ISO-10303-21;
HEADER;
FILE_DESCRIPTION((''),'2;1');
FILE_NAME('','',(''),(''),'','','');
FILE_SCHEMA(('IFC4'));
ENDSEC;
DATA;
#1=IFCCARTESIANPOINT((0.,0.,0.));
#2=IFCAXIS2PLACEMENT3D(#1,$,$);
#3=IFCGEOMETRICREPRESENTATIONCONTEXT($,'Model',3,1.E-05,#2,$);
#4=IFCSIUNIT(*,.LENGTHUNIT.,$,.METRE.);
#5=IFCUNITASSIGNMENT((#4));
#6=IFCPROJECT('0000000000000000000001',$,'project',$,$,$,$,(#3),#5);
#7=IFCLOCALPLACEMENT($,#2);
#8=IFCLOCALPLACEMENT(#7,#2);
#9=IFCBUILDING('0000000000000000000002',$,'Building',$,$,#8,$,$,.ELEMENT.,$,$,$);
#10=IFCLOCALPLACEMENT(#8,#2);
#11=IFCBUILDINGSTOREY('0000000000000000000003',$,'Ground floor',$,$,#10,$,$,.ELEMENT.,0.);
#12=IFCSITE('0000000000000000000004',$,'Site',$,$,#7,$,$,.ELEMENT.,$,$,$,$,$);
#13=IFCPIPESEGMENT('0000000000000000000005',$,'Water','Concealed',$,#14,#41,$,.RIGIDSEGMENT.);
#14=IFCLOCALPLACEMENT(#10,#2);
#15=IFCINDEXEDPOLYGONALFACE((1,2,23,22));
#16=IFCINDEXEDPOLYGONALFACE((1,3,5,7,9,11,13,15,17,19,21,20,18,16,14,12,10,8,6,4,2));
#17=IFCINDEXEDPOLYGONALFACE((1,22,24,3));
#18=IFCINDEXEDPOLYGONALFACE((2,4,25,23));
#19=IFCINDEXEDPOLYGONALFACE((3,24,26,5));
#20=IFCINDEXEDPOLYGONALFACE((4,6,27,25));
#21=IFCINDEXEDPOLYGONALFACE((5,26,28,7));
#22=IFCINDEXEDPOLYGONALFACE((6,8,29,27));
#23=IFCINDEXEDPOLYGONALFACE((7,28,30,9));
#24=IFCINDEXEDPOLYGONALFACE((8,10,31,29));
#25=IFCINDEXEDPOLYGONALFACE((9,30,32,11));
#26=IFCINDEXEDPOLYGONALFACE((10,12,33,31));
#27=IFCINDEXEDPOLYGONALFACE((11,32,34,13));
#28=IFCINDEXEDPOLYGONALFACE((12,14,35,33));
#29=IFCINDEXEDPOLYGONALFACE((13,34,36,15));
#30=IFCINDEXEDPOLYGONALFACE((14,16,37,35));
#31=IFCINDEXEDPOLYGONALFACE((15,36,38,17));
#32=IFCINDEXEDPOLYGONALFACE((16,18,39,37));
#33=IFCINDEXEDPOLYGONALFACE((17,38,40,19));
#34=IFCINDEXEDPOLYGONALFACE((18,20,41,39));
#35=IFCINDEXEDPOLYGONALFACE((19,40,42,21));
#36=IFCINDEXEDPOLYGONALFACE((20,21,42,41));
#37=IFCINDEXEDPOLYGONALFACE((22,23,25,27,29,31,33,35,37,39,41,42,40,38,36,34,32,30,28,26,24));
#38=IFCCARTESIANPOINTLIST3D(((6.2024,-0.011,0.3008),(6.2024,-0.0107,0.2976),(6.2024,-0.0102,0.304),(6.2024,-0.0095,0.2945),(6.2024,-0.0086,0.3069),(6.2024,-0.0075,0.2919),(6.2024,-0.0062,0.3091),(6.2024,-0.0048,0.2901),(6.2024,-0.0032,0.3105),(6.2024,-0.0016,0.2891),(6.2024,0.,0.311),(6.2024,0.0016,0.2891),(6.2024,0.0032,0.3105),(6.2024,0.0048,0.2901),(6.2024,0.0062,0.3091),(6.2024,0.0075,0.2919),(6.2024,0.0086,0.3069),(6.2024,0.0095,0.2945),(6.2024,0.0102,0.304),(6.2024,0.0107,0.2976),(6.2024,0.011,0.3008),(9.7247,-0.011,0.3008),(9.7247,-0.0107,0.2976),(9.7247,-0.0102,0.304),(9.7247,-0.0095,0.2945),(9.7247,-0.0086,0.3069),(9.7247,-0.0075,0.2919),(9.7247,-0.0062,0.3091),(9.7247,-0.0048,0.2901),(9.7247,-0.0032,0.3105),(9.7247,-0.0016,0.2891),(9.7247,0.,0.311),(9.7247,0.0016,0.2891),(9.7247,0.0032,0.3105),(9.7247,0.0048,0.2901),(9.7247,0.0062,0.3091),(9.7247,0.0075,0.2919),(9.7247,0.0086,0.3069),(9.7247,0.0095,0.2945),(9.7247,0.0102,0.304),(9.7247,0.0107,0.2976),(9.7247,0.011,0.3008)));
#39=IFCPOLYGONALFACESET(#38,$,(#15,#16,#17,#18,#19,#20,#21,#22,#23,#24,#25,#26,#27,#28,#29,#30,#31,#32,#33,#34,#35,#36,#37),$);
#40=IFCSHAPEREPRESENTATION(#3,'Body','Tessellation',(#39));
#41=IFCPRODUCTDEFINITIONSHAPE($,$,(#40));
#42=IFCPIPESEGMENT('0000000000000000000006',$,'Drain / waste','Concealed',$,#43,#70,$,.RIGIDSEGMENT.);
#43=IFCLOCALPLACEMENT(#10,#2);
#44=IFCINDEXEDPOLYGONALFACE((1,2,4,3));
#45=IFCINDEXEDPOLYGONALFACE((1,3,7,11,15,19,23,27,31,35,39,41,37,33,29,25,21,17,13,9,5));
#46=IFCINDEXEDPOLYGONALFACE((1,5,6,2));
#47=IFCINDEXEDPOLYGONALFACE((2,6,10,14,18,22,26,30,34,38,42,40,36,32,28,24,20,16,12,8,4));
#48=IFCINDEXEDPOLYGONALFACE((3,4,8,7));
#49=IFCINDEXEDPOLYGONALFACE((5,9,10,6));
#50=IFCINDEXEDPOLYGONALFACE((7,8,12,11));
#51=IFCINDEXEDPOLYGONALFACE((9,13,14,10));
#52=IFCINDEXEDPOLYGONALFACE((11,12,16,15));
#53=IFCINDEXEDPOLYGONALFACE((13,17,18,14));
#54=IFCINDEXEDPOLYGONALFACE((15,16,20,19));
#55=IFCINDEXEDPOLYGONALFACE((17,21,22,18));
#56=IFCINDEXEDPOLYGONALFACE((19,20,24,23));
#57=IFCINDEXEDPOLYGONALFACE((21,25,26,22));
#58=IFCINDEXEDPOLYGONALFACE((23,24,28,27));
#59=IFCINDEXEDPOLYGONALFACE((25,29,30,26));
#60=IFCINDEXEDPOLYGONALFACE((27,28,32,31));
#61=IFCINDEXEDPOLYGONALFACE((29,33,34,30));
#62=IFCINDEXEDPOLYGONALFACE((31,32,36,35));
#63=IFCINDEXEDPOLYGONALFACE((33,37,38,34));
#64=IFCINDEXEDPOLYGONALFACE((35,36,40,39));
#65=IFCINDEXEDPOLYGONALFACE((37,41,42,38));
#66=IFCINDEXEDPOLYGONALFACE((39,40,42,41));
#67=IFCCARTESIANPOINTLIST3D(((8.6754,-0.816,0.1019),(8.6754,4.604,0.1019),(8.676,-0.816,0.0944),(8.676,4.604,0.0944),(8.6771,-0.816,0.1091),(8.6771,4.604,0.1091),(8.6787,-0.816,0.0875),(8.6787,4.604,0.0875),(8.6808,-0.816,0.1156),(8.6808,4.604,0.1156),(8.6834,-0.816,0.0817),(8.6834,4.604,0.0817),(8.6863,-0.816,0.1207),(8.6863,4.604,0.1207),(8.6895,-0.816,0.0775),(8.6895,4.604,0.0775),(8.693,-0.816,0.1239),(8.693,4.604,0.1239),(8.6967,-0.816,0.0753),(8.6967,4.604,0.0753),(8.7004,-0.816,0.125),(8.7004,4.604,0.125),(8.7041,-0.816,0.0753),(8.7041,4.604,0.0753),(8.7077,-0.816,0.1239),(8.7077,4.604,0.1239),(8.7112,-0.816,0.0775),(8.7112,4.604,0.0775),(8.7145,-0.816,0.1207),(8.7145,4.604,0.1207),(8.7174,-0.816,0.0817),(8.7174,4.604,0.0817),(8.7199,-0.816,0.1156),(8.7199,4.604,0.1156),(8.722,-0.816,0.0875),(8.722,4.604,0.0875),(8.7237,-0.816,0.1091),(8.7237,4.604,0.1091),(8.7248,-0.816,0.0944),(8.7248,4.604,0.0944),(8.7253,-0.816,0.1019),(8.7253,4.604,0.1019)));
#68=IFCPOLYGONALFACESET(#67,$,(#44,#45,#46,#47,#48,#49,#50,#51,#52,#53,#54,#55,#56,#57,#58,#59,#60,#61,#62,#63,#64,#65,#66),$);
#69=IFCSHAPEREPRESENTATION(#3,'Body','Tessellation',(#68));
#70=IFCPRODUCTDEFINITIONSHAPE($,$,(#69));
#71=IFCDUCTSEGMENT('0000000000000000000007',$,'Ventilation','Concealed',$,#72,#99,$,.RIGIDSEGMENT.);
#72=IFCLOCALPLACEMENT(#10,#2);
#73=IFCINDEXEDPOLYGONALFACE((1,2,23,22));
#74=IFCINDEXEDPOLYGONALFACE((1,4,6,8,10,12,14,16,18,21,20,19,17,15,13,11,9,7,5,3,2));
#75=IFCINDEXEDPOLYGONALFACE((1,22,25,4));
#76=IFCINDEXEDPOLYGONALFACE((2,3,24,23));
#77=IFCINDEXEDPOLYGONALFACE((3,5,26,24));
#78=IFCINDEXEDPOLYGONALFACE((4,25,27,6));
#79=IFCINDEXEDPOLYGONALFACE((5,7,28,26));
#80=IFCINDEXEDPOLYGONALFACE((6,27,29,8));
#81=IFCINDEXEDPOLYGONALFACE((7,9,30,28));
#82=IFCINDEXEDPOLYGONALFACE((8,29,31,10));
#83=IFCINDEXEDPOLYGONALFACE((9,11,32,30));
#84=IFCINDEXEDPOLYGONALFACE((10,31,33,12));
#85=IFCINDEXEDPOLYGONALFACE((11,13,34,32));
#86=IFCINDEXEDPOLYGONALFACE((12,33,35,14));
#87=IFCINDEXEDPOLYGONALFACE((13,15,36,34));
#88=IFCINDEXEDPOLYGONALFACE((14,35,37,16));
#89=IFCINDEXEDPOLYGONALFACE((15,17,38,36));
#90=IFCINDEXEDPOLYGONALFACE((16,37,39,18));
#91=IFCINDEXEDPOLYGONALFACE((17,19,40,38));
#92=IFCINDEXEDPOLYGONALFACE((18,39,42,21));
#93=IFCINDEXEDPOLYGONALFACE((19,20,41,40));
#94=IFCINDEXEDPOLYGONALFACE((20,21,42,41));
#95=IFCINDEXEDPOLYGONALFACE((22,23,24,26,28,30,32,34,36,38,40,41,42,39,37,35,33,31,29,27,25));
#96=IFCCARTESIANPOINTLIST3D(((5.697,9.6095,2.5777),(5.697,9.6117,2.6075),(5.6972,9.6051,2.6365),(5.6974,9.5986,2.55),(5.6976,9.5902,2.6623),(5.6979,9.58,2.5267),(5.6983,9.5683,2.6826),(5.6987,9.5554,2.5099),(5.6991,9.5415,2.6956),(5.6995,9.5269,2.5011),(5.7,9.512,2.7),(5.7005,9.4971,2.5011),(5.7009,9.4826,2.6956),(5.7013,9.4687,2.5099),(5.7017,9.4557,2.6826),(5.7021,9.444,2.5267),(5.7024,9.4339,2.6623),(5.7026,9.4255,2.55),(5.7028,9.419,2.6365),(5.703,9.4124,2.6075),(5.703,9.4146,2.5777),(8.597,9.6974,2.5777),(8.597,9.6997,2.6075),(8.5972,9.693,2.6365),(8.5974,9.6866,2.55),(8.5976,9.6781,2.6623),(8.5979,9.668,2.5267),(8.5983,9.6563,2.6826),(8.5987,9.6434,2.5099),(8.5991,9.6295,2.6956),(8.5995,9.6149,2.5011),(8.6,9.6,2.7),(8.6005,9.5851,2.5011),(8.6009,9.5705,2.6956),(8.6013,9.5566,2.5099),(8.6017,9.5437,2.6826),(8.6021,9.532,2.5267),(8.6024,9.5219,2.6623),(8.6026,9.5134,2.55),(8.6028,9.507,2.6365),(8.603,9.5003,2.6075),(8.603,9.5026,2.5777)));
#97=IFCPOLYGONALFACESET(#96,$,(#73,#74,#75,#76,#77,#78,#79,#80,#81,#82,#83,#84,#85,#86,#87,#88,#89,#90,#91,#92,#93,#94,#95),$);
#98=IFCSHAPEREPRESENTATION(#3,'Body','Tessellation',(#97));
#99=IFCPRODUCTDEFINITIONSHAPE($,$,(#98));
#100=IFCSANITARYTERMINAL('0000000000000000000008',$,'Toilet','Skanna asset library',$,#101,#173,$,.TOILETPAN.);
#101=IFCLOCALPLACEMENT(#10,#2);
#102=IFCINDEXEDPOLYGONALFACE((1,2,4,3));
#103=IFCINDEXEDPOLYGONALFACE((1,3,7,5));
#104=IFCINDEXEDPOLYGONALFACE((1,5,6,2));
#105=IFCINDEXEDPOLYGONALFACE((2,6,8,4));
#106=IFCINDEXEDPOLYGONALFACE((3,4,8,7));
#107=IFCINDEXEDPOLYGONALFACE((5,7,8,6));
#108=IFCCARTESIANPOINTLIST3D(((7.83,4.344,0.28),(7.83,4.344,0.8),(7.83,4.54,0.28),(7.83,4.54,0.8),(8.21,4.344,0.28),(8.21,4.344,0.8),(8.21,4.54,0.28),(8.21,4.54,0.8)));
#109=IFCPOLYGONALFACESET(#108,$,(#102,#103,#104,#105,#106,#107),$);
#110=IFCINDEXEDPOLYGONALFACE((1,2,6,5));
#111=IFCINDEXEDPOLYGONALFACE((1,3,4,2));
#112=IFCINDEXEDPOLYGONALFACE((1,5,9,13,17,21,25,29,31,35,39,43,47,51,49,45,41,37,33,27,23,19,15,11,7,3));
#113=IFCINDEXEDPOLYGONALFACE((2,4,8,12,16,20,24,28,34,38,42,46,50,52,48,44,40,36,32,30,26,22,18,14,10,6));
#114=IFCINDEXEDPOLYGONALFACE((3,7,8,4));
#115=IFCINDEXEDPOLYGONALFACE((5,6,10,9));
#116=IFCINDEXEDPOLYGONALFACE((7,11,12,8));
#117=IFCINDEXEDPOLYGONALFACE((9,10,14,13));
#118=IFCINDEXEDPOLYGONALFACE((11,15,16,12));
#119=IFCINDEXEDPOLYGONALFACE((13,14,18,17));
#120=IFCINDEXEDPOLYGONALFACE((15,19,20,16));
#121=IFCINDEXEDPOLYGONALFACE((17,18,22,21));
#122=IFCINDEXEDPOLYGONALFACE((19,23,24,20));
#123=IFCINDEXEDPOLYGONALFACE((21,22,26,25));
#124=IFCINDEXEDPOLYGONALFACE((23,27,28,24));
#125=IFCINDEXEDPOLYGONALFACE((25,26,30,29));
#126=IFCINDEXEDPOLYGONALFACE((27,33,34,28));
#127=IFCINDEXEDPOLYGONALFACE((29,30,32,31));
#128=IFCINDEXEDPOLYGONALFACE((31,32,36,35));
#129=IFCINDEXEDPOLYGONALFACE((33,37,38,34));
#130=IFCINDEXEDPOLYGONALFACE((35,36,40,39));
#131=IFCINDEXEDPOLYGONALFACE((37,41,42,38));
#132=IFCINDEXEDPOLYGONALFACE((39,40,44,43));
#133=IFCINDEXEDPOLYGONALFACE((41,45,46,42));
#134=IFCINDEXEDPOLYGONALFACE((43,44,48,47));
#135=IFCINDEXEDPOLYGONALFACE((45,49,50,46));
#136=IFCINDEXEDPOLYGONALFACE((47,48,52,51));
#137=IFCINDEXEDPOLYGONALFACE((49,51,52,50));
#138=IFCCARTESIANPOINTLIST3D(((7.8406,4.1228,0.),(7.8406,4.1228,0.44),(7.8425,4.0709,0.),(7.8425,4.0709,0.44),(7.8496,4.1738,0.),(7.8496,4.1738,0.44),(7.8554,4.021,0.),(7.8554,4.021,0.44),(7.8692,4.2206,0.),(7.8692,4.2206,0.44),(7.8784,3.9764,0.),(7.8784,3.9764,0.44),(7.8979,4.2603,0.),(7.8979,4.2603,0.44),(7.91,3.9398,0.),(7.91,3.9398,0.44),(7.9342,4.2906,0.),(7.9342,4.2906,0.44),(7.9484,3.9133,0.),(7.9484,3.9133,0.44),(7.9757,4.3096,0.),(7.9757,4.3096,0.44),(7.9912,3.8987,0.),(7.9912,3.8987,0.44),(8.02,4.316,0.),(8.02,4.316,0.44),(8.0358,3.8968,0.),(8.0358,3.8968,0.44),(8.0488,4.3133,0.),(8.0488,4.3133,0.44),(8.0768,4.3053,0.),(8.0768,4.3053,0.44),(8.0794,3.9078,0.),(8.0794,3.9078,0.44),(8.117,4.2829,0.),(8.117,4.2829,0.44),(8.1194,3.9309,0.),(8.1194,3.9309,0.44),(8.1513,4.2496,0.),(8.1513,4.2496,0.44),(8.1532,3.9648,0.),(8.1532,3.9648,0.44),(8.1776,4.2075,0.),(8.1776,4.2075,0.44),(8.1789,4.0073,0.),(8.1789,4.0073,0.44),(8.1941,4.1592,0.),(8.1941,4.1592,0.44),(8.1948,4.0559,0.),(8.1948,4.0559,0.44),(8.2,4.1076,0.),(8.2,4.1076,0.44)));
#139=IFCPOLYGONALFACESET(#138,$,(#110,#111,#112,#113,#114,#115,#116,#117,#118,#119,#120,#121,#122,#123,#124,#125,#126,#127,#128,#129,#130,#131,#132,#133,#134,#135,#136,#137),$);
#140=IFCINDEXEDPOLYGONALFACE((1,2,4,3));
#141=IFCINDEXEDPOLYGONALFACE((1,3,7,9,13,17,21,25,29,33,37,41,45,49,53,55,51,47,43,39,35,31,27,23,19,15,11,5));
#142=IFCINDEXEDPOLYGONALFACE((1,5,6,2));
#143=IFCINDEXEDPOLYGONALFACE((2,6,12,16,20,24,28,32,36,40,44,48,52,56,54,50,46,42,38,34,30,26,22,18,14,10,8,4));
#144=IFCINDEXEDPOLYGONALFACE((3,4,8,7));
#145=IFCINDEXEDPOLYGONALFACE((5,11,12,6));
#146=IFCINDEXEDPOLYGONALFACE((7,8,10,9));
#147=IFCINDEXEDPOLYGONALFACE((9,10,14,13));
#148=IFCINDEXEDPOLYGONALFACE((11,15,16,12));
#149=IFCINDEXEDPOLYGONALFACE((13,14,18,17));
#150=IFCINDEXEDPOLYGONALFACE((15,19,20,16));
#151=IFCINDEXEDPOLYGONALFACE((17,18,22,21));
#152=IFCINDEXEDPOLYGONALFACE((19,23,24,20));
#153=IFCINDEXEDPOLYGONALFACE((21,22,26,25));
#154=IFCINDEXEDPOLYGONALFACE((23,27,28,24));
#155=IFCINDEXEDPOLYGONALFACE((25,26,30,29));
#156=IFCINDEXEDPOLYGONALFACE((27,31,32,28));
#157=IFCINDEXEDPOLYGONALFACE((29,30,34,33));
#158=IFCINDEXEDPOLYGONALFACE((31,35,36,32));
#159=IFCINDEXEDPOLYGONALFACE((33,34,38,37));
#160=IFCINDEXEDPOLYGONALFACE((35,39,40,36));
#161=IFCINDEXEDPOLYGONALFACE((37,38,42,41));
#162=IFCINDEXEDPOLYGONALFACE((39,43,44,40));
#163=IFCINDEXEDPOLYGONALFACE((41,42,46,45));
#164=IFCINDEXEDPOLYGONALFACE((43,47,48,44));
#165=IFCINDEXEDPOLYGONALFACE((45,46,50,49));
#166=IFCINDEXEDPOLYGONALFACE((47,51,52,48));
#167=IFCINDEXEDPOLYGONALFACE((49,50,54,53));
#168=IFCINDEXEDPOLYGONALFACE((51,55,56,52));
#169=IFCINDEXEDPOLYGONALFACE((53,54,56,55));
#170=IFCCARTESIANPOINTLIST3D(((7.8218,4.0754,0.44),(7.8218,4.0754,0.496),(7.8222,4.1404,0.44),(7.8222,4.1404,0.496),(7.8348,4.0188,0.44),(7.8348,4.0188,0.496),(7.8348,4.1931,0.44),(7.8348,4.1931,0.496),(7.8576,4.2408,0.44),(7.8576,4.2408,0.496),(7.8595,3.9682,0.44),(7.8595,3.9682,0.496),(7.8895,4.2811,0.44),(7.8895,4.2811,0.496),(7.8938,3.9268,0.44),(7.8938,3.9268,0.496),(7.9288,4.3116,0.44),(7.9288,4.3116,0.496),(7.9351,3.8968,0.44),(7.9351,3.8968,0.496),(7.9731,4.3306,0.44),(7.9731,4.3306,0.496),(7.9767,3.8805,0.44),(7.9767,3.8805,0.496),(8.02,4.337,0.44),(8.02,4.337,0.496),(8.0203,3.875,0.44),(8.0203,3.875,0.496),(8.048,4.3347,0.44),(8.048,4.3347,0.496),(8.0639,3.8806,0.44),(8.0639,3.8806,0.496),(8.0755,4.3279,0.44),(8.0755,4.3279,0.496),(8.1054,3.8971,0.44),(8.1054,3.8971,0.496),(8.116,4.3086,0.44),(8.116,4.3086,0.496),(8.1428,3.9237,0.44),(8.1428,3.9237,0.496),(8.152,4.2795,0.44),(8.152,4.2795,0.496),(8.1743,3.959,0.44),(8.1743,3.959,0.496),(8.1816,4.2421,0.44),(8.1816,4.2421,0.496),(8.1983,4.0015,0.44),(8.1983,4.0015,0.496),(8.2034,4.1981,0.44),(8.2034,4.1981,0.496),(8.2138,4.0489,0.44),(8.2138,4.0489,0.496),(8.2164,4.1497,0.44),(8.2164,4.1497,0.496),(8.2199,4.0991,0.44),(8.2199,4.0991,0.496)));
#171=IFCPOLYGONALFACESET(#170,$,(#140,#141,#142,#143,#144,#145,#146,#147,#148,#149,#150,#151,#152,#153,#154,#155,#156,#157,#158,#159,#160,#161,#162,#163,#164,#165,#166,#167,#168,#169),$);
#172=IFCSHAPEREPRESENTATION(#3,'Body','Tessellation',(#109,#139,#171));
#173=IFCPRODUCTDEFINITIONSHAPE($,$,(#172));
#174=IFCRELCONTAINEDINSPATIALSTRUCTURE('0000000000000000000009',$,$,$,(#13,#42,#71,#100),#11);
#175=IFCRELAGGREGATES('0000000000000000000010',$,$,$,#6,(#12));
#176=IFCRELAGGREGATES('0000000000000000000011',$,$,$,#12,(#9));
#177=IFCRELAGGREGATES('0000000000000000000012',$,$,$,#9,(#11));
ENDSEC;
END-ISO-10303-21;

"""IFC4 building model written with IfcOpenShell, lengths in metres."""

from ifc_helpers import new_model, si_unit, frame, frame_2d, origin, origin_2d, place, context, project, spatial, rectangle, circle, ellipse, extrude, element, save


model = new_model("IFC4")

# Units and contexts
model_context = context("Model", 3, precision=1e-05, world=origin())
ifc_project = project(units=[si_unit("LENGTHUNIT", "METRE")], contexts=[model_context])

# Site, building, storey
site_placement = place(None, origin())
site = spatial("IfcSite", under=ifc_project, at=site_placement, Name="Site", CompositionType="ELEMENT")
building_placement = place(site_placement, origin())
building = spatial("IfcBuilding", under=site, at=building_placement, Name="Building", CompositionType="ELEMENT")
storey_placement = place(building_placement, origin())
storey = spatial("IfcBuildingStorey", under=building, at=storey_placement, Name="Ground floor", CompositionType="ELEMENT", Elevation=0.0)

# Pipe segments
pipe_segment_1_placement = place(storey_placement, frame((9.7247, 0.0, 0.3), z_axis=(-1.0, 0.0, 0.0), x_axis=(0.0, 0.0, 1.0)))
element("IfcPipeSegment", 1, at=pipe_segment_1_placement, inside=storey, Name="Water", Description="Concealed", PredefinedType="RIGIDSEGMENT", context=model_context, shape_type="SweptSolid", body=[
    extrude(circle(Radius=0.011, at=origin_2d()), origin(), (0.0, 0.0, 1.0), 3.5224),
])
pipe_segment_2_placement = place(storey_placement, frame((8.7004, 4.604, 0.1), z_axis=(0.0, -1.0, 0.0), x_axis=(0.0, 0.0, 1.0)))
element("IfcPipeSegment", 2, at=pipe_segment_2_placement, inside=storey, Name="Drain / waste", Description="Concealed", PredefinedType="RIGIDSEGMENT", context=model_context, shape_type="SweptSolid", body=[
    extrude(circle(Radius=0.025, at=origin_2d()), origin(), (0.0, 0.0, 1.0), 5.42),
])

# Duct segment
duct_segment_placement = place(storey_placement, frame((8.6, 9.6, 2.6), z_axis=(-0.99954, -0.030322, 0.0), x_axis=(0.0, 0.0, 1.0)))
element("IfcDuctSegment", 3, at=duct_segment_placement, inside=storey, Name="Ventilation", Description="Concealed", PredefinedType="RIGIDSEGMENT", context=model_context, shape_type="SweptSolid", body=[
    extrude(circle(Radius=0.1, at=origin_2d()), origin(), (0.0, 0.0, 1.0), 2.9013),
])

# Sanitary terminal
sanitary_terminal_placement = place(storey_placement, frame((8.02, 4.19, 0.0), z_axis=(0.0, 0.0, 1.0), x_axis=(1.0, 0.0, 0.0)))
element("IfcSanitaryTerminal", 4, at=sanitary_terminal_placement, inside=storey, Name="Toilet", Description="Skanna asset library", PredefinedType="TOILETPAN", context=model_context, shape_type="SweptSolid", body=[
    extrude(rectangle(XDim=0.38, YDim=0.196, at=frame_2d((0.0, 0.252))), frame((0.0, 0.0, 0.28)), (0.0, 0.0, 1.0), 0.52),
    extrude(ellipse(SemiAxis1=0.18, SemiAxis2=0.21, at=frame_2d((0.0, -0.084))), origin(), (0.0, 0.0, 1.0), 0.44),
    extrude(ellipse(SemiAxis1=0.2, SemiAxis2=0.231, at=frame_2d((0.0, -0.084))), frame((0.0, 0.0, 0.44)), (0.0, 0.0, 1.0), 0.056),
])

save(model, "model.ifc")
